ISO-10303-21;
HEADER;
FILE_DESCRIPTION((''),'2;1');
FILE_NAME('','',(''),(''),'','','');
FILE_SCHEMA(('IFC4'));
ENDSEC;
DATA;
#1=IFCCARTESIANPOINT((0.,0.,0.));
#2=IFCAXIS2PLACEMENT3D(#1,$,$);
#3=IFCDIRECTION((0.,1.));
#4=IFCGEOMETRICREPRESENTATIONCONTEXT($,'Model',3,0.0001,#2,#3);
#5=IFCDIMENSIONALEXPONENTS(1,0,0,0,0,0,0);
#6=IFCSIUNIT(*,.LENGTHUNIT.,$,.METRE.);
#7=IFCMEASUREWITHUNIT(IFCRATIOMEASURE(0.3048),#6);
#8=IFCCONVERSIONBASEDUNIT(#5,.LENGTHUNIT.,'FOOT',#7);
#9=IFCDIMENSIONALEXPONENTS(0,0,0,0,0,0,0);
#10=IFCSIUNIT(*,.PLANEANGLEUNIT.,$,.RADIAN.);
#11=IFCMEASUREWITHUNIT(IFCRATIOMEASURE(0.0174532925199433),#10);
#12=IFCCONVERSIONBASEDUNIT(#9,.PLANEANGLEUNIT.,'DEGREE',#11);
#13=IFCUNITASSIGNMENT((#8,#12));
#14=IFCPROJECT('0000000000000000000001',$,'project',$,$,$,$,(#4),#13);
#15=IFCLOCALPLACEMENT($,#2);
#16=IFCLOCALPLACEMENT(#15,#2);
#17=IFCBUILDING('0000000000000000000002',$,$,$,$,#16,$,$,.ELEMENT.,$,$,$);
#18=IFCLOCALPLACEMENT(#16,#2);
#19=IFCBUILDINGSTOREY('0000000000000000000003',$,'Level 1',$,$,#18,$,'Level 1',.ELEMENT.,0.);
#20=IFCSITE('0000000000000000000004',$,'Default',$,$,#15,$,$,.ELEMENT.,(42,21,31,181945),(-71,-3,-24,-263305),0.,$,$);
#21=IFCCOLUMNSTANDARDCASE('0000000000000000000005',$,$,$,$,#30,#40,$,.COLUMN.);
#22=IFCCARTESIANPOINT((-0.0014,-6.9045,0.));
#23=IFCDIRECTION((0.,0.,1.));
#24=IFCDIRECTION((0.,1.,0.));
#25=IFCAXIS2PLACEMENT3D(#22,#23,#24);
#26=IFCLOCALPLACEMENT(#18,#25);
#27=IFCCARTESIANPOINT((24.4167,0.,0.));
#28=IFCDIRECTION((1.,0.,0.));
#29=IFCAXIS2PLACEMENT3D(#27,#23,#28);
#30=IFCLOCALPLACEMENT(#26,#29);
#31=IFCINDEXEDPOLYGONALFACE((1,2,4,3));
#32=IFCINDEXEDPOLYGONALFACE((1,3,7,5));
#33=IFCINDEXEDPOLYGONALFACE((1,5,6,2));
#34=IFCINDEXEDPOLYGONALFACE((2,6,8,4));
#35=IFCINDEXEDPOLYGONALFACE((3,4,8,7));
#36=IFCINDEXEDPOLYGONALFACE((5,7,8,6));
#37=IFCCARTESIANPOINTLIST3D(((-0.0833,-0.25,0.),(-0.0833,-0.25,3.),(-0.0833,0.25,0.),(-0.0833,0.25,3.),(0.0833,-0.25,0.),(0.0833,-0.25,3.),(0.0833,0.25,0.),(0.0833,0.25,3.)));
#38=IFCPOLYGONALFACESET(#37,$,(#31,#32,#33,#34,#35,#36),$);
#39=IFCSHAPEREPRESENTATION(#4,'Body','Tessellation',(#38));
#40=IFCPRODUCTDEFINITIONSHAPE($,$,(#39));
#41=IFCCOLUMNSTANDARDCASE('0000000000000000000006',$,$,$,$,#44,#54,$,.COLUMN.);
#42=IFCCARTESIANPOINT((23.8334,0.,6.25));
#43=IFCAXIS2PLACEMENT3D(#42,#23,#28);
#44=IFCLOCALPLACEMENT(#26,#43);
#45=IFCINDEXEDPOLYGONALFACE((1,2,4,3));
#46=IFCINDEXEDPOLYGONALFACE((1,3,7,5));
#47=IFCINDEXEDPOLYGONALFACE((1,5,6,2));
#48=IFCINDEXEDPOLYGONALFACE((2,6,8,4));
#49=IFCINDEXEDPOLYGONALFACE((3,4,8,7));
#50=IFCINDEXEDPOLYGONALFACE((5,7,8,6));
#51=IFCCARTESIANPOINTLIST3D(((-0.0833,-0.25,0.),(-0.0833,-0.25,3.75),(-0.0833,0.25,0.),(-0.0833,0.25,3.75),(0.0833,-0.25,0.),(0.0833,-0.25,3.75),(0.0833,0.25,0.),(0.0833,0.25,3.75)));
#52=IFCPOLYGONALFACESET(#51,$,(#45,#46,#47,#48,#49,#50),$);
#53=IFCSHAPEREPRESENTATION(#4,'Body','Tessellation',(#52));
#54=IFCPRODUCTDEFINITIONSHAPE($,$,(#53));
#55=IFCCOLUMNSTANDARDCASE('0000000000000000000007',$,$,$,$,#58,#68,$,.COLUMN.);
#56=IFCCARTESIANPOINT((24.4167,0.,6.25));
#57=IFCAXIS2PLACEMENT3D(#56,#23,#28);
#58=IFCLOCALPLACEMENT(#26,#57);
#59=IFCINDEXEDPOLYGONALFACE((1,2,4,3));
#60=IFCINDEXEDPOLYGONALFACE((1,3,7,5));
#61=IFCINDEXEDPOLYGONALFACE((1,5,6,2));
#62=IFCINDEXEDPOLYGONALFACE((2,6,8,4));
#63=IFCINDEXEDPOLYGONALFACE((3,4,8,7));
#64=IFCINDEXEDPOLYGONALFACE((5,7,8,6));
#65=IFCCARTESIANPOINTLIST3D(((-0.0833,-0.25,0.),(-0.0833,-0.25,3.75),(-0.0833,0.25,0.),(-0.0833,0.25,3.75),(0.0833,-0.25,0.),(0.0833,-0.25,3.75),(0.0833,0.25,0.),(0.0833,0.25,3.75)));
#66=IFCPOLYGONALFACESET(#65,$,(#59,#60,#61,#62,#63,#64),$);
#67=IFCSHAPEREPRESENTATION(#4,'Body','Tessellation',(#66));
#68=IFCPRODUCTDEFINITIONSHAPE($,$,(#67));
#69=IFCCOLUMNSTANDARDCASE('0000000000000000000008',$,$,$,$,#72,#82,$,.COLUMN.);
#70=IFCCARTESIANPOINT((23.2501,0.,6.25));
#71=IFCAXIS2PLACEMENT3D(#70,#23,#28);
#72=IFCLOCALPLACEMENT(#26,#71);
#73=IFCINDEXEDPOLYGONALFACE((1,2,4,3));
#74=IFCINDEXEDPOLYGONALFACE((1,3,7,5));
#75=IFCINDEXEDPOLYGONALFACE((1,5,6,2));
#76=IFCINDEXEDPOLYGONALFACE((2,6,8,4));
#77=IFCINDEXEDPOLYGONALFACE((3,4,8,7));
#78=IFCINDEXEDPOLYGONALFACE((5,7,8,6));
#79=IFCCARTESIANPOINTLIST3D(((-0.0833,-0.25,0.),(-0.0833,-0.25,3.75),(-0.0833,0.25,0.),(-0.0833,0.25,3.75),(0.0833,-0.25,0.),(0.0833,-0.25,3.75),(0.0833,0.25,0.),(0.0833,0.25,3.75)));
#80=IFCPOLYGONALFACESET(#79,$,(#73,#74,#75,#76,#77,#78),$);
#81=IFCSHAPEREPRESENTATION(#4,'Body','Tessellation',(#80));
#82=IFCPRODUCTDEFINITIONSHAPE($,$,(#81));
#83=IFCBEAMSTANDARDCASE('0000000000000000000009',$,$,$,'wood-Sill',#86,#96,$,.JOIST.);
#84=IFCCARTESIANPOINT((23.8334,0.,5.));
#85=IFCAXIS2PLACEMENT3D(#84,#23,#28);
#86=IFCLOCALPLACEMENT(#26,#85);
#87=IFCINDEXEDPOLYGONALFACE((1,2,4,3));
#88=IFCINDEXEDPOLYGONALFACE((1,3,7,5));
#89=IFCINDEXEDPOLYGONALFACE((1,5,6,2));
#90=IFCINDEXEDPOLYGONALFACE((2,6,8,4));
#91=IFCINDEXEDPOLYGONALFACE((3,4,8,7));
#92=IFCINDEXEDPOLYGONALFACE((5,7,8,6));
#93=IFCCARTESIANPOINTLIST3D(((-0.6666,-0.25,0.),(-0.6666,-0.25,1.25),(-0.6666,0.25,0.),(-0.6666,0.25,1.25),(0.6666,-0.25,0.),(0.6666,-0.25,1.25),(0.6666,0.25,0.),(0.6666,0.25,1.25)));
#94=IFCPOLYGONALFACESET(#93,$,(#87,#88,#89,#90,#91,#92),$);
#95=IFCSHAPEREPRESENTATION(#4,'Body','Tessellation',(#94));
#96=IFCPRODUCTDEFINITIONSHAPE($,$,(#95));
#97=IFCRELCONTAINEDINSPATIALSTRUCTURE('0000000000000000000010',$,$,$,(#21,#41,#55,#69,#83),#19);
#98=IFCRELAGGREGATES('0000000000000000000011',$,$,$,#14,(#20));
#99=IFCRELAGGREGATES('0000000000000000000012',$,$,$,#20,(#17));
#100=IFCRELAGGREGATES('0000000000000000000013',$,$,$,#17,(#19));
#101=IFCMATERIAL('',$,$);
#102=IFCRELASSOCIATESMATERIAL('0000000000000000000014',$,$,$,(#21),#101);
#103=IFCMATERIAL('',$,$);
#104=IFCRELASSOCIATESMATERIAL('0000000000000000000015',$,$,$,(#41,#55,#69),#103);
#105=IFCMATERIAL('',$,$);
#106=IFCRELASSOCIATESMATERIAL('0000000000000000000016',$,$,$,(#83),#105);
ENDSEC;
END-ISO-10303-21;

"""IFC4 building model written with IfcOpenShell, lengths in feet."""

from ifc_helpers import new_model, entity, si_unit, converted_unit, direction, frame, origin, place, context, project, spatial, rectangle, extrude, material, element, save


model = new_model("IFC4")

# Units and contexts
model_context = context("Model", 3, precision=0.0001, world=origin(), true_north=direction((0.0, 1.0)))
ifc_project = project(units=[converted_unit("LENGTHUNIT", "FOOT", entity("IfcRatioMeasure", 0.3048), si_unit("LENGTHUNIT", "METRE"), dimensions=[1, 0, 0, 0, 0, 0, 0]), converted_unit("PLANEANGLEUNIT", "DEGREE", entity("IfcRatioMeasure", 0.0174532925199433), si_unit("PLANEANGLEUNIT", "RADIAN"), dimensions=[0, 0, 0, 0, 0, 0, 0])], contexts=[model_context])

# Site, building, storey
site_placement = place(None, origin())
site = spatial("IfcSite", under=ifc_project, at=site_placement, Name="Default", CompositionType="ELEMENT", RefLatitude=(42, 21, 31, 181945), RefLongitude=(-71, -3, -24, -263305), RefElevation=0.0)
building_placement = place(site_placement, origin())
building = spatial("IfcBuilding", under=site, at=building_placement, CompositionType="ELEMENT")
storey_placement = place(building_placement, origin())
storey = spatial("IfcBuildingStorey", under=building, at=storey_placement, Name="Level 1", LongName="Level 1", CompositionType="ELEMENT", Elevation=0.0)

# Columns
placement_1 = place(storey_placement, frame((-0.0014, -6.9045, 0.0), z_axis=(0.0, 0.0, 1.0), x_axis=(0.0, 1.0, 0.0)))
ifc_material_1 = material(Name="")
for number, where, z_axis, x_axis in (
    (1, (24.4167, 0.0, 0.0), (0.0, 0.0, 1.0), (1.0, 0.0, 0.0)),
):
    element("IfcColumnStandardCase", number, at=place(placement_1, frame(where, z_axis=z_axis, x_axis=x_axis)), inside=storey, material=ifc_material_1, PredefinedType="COLUMN", context=model_context, shape_type="SweptSolid", body=[
        extrude(rectangle(XDim=0.1667, YDim=0.5), origin(), (0.0, 0.0, 1.0), 3.0),
    ])
ifc_material_2 = material(Name="")
for number, where, z_axis, x_axis in (
    (2, (23.8334, 0.0, 6.25), (0.0, 0.0, 1.0), (1.0, 0.0, 0.0)),
    (3, (24.4167, 0.0, 6.25), (0.0, 0.0, 1.0), (1.0, 0.0, 0.0)),
    (4, (23.2501, 0.0, 6.25), (0.0, 0.0, 1.0), (1.0, 0.0, 0.0)),
):
    element("IfcColumnStandardCase", number, at=place(placement_1, frame(where, z_axis=z_axis, x_axis=x_axis)), inside=storey, material=ifc_material_2, PredefinedType="COLUMN", context=model_context, shape_type="SweptSolid", body=[
        extrude(rectangle(XDim=0.1667, YDim=0.5), origin(), (0.0, 0.0, 1.0), 3.75),
    ])

# Beam
ifc_material_3 = material(Name="")
for number, where, z_axis, x_axis in (
    (5, (23.8334, 0.0, 5.0), (0.0, 0.0, 1.0), (1.0, 0.0, 0.0)),
):
    element("IfcBeamStandardCase", number, at=place(placement_1, frame(where, z_axis=z_axis, x_axis=x_axis)), inside=storey, material=ifc_material_3, ObjectType="wood-Sill", PredefinedType="JOIST", context=model_context, shape_type="SweptSolid", body=[
        extrude(rectangle(XDim=1.3333, YDim=0.5), origin(), (0.0, 0.0, 1.0), 1.25),
    ])

save(model, "model.ifc")
